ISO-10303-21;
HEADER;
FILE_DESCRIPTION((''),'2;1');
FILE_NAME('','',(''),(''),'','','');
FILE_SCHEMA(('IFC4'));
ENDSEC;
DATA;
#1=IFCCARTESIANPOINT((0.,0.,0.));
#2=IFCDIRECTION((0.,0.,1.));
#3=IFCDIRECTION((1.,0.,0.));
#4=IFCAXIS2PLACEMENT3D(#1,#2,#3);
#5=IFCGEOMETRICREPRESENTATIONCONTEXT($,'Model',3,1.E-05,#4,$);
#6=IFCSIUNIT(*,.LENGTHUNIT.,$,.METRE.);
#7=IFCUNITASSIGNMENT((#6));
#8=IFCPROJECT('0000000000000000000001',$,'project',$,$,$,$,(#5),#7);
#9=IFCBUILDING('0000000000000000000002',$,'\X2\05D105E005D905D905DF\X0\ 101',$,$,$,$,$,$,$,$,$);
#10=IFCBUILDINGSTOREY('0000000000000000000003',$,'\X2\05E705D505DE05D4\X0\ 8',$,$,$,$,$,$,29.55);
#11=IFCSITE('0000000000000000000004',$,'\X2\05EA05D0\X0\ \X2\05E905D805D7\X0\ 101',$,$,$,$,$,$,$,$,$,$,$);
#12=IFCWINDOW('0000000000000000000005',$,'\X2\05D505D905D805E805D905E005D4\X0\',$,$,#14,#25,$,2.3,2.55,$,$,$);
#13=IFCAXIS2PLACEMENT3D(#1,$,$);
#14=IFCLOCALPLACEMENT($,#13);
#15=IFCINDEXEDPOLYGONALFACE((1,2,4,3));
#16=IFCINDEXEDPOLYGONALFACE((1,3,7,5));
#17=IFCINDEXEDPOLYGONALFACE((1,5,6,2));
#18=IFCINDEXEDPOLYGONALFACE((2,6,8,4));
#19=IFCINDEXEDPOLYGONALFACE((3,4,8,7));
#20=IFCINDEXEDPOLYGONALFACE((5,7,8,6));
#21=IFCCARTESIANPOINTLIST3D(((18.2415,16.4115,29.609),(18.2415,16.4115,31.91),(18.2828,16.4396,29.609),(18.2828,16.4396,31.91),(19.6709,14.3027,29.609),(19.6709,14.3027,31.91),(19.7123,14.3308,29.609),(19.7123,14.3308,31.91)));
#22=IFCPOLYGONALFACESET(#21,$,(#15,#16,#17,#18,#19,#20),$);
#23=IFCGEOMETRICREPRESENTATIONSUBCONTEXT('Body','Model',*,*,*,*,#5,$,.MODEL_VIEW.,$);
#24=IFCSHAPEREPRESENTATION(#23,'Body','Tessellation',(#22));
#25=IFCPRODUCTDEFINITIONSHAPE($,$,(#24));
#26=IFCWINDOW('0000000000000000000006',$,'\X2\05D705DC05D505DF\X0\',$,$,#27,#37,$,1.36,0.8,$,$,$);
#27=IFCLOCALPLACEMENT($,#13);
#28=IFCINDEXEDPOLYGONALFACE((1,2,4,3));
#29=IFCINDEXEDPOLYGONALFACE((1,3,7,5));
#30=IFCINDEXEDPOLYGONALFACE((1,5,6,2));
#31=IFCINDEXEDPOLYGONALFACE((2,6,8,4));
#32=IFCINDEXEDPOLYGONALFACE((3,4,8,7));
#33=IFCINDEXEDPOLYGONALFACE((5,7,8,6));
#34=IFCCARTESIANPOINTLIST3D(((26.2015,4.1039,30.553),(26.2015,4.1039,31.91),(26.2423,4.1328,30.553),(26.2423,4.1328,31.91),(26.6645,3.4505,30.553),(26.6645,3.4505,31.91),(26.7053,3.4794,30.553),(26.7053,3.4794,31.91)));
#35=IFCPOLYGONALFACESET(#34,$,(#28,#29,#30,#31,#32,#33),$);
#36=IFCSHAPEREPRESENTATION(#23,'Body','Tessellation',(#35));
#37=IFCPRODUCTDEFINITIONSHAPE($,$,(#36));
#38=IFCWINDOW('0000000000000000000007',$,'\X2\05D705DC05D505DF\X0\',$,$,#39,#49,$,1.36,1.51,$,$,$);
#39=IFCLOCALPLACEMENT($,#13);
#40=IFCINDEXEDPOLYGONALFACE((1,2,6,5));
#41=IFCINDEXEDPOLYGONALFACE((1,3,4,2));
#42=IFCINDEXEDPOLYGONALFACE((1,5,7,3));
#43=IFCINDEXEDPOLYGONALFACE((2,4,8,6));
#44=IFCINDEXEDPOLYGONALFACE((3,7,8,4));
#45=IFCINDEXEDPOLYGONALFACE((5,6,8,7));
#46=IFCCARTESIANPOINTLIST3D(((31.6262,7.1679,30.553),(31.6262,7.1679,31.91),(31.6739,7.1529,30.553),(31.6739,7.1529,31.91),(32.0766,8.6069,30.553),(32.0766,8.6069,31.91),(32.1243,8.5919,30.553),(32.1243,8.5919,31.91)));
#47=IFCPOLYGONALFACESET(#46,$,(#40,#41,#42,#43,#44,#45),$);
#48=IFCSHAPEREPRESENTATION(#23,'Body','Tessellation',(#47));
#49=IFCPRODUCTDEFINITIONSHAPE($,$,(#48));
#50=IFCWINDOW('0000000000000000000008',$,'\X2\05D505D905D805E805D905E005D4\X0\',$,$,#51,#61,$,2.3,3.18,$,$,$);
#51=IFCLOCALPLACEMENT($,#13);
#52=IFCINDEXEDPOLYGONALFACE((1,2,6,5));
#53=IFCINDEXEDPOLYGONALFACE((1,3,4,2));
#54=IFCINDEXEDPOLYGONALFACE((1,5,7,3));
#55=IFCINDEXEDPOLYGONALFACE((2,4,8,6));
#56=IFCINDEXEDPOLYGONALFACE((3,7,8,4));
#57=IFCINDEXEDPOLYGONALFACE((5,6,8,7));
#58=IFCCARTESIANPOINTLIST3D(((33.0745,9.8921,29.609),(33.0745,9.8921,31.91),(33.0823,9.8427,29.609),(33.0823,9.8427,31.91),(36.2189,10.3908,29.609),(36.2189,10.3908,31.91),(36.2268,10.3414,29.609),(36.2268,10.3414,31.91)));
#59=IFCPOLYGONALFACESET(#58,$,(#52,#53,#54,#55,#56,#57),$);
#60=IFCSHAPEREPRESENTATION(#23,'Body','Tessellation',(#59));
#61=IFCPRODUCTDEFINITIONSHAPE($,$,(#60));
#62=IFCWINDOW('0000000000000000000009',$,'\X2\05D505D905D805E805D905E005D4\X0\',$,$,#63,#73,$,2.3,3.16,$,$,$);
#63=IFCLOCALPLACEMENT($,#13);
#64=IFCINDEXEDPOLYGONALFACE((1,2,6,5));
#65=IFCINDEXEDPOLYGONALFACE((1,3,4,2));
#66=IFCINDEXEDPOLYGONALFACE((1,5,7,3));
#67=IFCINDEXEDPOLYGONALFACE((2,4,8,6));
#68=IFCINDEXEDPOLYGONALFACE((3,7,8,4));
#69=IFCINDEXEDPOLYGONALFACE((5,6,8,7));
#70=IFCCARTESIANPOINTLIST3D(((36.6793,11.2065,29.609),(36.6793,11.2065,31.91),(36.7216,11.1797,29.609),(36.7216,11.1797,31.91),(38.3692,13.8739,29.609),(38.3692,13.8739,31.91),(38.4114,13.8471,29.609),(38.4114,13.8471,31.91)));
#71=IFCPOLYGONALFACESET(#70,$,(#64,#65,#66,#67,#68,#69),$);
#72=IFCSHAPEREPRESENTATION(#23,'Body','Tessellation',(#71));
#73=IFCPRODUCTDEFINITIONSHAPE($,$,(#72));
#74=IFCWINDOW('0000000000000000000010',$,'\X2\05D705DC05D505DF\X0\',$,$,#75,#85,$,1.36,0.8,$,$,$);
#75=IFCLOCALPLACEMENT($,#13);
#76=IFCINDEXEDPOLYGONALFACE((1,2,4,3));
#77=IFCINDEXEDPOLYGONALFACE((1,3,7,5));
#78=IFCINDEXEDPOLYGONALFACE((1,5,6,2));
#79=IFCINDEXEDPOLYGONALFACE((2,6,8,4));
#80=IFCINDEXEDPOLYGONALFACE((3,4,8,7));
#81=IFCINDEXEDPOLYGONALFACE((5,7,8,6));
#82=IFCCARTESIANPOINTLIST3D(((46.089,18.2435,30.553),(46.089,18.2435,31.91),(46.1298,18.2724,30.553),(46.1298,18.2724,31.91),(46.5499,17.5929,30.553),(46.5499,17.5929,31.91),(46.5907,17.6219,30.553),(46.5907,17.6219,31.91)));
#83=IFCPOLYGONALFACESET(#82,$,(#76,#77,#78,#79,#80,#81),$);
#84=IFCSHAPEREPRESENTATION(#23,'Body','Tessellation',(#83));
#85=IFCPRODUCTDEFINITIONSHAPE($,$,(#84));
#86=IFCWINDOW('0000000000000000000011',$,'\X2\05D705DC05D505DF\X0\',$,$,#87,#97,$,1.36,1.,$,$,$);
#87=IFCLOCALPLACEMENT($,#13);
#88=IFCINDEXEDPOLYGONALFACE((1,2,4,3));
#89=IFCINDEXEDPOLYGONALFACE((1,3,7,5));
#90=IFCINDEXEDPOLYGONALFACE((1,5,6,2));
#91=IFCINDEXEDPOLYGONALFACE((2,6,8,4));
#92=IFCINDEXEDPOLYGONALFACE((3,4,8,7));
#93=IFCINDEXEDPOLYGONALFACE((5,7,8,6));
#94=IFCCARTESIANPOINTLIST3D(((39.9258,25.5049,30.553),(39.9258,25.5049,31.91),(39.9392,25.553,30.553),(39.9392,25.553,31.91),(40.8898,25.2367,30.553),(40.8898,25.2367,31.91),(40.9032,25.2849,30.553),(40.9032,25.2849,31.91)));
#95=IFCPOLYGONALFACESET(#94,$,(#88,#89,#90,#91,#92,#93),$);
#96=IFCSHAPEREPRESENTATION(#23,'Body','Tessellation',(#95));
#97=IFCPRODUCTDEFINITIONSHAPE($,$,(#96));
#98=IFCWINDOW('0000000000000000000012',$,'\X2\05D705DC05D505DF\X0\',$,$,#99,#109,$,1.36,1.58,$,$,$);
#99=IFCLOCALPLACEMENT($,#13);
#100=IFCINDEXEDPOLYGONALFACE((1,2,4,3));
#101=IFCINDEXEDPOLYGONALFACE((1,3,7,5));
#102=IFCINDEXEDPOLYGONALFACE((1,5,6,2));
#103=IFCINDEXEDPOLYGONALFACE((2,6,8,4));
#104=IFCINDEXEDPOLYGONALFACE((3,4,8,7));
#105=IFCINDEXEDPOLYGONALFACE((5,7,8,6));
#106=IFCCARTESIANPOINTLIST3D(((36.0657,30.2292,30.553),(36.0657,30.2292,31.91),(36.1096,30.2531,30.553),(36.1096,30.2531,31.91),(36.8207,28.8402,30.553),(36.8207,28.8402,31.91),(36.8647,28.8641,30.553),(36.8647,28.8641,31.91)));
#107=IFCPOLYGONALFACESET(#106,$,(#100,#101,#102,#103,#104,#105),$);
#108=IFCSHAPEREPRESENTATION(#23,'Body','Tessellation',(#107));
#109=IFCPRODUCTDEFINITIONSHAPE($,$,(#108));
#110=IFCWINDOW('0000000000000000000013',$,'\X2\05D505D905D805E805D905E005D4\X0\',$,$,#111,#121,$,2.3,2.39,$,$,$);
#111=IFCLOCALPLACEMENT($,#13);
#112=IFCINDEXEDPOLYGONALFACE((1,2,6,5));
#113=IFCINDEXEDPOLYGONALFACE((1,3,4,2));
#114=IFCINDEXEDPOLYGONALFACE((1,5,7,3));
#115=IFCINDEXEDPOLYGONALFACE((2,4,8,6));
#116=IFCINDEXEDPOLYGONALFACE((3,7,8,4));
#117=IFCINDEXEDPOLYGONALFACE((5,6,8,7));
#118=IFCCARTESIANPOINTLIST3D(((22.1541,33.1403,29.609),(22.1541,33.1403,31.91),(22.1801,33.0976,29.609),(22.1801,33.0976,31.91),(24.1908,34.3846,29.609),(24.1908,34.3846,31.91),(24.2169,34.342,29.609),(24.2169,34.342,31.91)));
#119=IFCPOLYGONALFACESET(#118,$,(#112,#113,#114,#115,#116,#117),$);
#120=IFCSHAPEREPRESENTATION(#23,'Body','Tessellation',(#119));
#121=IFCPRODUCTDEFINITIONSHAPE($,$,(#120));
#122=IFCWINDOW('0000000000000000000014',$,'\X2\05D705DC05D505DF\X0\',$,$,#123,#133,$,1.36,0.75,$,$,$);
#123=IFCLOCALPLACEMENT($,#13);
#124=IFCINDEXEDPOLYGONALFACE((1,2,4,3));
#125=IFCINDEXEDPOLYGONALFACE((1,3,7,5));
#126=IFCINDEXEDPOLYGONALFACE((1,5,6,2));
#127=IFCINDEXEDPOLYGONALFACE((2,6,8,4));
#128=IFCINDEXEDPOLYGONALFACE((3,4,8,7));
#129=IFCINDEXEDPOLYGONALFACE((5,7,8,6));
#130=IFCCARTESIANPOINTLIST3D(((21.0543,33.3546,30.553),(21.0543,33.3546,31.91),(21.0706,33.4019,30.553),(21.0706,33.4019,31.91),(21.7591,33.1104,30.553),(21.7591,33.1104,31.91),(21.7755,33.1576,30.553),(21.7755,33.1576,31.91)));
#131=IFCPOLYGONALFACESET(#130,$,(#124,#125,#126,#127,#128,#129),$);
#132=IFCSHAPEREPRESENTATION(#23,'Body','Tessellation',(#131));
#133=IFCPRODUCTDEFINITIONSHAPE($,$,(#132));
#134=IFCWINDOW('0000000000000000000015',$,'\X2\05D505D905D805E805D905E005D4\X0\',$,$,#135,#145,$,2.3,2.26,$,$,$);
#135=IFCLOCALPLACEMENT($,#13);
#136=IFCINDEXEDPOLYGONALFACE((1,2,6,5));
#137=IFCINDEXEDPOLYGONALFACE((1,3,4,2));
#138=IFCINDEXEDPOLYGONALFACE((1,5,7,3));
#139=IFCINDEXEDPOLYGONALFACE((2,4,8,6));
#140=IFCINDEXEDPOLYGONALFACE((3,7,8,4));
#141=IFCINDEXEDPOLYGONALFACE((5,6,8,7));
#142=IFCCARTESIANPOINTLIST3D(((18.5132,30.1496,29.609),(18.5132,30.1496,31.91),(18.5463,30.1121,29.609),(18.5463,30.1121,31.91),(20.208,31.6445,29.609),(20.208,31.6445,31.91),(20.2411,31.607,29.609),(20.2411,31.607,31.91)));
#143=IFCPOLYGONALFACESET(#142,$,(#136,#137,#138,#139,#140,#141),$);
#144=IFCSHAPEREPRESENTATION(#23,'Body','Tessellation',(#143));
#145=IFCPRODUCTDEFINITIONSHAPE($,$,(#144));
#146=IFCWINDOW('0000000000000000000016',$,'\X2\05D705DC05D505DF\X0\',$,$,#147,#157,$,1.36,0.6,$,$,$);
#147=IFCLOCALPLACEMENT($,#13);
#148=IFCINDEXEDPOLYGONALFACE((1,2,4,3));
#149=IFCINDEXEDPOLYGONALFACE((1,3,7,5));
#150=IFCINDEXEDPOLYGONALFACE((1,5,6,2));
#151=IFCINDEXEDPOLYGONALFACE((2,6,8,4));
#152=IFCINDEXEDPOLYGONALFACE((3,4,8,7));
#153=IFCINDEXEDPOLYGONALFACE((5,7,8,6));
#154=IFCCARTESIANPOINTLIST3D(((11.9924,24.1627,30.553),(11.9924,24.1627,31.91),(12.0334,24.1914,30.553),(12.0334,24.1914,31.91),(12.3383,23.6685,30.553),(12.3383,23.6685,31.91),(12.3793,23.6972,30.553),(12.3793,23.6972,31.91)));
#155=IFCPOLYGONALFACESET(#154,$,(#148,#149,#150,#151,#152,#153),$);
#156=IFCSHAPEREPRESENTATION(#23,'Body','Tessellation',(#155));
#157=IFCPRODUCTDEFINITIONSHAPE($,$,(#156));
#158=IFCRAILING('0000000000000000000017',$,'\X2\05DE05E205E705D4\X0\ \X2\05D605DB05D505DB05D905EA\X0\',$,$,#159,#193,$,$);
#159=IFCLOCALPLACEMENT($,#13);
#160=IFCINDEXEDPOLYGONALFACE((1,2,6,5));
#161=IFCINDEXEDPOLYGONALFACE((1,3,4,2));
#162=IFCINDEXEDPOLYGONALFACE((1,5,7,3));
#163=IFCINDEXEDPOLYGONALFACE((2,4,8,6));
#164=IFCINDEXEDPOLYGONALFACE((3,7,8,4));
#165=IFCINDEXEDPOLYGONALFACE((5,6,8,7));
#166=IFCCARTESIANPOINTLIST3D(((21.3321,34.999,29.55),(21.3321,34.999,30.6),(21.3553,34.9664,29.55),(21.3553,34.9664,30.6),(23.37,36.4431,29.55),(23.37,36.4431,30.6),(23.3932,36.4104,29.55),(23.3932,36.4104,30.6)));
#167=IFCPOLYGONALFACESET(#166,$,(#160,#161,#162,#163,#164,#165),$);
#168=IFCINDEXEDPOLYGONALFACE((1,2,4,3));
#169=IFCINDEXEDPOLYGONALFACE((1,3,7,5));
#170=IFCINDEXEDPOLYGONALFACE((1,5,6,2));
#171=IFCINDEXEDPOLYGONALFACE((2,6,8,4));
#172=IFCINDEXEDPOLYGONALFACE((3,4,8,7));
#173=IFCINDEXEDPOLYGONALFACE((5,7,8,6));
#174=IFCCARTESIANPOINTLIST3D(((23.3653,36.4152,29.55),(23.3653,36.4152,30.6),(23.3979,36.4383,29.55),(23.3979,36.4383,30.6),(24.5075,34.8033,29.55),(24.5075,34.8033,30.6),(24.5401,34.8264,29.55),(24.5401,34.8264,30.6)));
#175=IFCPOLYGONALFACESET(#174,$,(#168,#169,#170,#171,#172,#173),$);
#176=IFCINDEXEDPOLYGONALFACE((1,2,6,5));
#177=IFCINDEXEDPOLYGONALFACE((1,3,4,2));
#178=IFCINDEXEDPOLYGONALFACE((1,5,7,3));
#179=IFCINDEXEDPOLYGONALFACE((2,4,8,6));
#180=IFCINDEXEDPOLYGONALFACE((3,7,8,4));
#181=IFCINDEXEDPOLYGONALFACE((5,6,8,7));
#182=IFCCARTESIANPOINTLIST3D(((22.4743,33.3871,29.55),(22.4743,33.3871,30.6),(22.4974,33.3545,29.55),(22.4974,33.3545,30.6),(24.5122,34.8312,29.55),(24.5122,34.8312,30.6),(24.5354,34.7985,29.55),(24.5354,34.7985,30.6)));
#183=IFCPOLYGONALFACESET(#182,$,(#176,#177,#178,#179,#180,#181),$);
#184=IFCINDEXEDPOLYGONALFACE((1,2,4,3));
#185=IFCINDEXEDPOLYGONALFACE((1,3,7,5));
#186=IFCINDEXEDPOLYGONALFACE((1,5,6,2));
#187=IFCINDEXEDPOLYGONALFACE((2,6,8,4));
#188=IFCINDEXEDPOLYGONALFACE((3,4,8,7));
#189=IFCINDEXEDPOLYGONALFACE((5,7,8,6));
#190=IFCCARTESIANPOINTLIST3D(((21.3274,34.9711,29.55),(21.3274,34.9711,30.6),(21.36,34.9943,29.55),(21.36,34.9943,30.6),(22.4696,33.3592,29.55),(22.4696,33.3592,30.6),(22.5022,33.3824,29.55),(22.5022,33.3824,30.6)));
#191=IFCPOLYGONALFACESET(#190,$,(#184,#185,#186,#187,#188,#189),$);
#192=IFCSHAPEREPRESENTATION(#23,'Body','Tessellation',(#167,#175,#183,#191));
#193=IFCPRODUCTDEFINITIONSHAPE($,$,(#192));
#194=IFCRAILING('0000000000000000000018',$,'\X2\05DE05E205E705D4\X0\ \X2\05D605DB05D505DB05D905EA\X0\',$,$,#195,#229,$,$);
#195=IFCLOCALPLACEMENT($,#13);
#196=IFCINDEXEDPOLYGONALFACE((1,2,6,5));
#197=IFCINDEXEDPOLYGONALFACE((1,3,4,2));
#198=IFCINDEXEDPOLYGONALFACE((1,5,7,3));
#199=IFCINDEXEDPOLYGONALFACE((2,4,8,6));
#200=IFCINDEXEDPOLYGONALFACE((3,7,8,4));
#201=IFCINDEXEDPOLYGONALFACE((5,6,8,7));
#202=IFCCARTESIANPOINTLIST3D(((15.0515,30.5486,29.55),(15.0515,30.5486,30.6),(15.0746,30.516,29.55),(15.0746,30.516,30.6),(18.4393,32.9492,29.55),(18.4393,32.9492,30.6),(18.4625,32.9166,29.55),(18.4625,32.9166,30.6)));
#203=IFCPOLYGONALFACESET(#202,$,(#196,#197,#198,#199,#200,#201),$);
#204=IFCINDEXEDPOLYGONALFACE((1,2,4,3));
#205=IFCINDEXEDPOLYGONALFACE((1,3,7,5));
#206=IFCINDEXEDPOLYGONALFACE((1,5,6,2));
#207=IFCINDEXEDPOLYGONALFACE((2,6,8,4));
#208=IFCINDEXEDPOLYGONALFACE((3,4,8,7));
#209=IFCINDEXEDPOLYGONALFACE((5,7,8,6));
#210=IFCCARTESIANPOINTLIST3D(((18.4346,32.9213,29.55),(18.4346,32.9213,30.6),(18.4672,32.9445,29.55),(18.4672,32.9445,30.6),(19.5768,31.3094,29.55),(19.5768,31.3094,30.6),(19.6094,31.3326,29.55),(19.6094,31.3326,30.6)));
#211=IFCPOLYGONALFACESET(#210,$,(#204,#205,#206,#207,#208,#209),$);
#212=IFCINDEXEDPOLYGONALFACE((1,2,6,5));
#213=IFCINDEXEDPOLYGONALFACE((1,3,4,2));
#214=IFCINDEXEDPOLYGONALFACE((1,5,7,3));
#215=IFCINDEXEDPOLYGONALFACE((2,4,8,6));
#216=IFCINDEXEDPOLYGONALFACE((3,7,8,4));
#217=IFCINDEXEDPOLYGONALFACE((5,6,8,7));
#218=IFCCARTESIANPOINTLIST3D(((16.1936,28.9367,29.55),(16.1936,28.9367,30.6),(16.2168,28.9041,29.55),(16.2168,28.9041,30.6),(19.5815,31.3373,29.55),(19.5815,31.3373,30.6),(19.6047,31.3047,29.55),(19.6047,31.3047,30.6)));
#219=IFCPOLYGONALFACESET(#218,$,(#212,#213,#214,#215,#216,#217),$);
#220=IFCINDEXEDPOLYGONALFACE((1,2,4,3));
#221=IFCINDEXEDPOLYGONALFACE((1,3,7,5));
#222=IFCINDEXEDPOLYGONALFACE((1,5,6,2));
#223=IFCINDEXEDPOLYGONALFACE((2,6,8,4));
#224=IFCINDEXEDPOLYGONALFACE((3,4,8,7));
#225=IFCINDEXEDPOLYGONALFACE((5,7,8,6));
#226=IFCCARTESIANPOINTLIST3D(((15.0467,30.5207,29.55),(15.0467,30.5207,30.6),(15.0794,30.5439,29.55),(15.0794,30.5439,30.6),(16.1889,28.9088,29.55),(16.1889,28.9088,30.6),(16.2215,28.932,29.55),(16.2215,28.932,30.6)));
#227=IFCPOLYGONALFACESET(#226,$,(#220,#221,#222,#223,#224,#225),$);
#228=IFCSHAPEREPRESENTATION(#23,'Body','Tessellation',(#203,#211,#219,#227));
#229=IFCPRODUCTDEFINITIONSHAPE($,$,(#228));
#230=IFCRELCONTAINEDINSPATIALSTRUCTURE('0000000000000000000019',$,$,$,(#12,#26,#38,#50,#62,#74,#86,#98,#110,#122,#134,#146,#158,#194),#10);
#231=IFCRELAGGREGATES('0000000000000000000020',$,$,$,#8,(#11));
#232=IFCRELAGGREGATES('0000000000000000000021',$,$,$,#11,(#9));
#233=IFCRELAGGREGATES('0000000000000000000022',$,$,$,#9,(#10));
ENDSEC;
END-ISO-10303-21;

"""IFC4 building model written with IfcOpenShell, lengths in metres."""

from ifc_helpers import new_model, si_unit, frame, origin_with_axes, context, subcontext, project, spatial, polyline, outline, extrude, element, save


model = new_model("IFC4")

# Units and contexts
model_context = context("Model", 3, precision=1e-05, world=origin_with_axes())
body_context = subcontext(model_context, "Body", "Model", "MODEL_VIEW")
ifc_project = project(units=[si_unit("LENGTHUNIT", "METRE")], contexts=[model_context])

# Site, building, storey
site = spatial("IfcSite", under=ifc_project, Name="תא שטח 101")
building = spatial("IfcBuilding", under=site, Name="בניין 101")
storey = spatial("IfcBuildingStorey", under=building, Name="קומה 8", Elevation=29.55)

# Windows
element("IfcWindow", 1, inside=storey, Name="ויטרינה", OverallHeight=2.3, OverallWidth=2.55, context=body_context, shape_type="SweptSolid", body=[
    extrude(outline(polyline([(18.2415, 16.4115), (19.6709, 14.3027), (19.7123, 14.3308), (18.2828, 16.4396), (18.2415, 16.4115)])), frame((0.0, 0.0, 29.609)), (0.0, 0.0, 1.0), 2.301),
])
element("IfcWindow", 2, inside=storey, Name="חלון", OverallHeight=1.36, OverallWidth=0.8, context=body_context, shape_type="SweptSolid", body=[
    extrude(outline(polyline([(26.2015, 4.1039), (26.6645, 3.4505), (26.7053, 3.4794), (26.2423, 4.1328), (26.2015, 4.1039)])), frame((0.0, 0.0, 30.553)), (0.0, 0.0, 1.0), 1.357),
])
element("IfcWindow", 3, inside=storey, Name="חלון", OverallHeight=1.36, OverallWidth=1.51, context=body_context, shape_type="SweptSolid", body=[
    extrude(outline(polyline([(31.6739, 7.1529), (32.1243, 8.5919), (32.0766, 8.6069), (31.6262, 7.1679), (31.6739, 7.1529)])), frame((0.0, 0.0, 30.553)), (0.0, 0.0, 1.0), 1.357),
])
element("IfcWindow", 4, inside=storey, Name="ויטרינה", OverallHeight=2.3, OverallWidth=3.18, context=body_context, shape_type="SweptSolid", body=[
    extrude(outline(polyline([(33.0823, 9.8427), (36.2268, 10.3414), (36.2189, 10.3908), (33.0745, 9.8921), (33.0823, 9.8427)])), frame((0.0, 0.0, 29.609)), (0.0, 0.0, 1.0), 2.301),
])
element("IfcWindow", 5, inside=storey, Name="ויטרינה", OverallHeight=2.3, OverallWidth=3.16, context=body_context, shape_type="SweptSolid", body=[
    extrude(outline(polyline([(36.7216, 11.1797), (38.4114, 13.8471), (38.3692, 13.8739), (36.6793, 11.2065), (36.7216, 11.1797)])), frame((0.0, 0.0, 29.609)), (0.0, 0.0, 1.0), 2.301),
])
element("IfcWindow", 6, inside=storey, Name="חלון", OverallHeight=1.36, OverallWidth=0.8, context=body_context, shape_type="SweptSolid", body=[
    extrude(outline(polyline([(46.5907, 17.6219), (46.1298, 18.2724), (46.089, 18.2435), (46.5499, 17.5929), (46.5907, 17.6219)])), frame((0.0, 0.0, 30.553)), (0.0, 0.0, 1.0), 1.357),
])
element("IfcWindow", 7, inside=storey, Name="חלון", OverallHeight=1.36, OverallWidth=1.0, context=body_context, shape_type="SweptSolid", body=[
    extrude(outline(polyline([(40.9032, 25.2849), (39.9392, 25.553), (39.9258, 25.5049), (40.8898, 25.2367), (40.9032, 25.2849)])), frame((0.0, 0.0, 30.553)), (0.0, 0.0, 1.0), 1.357),
])
element("IfcWindow", 8, inside=storey, Name="חלון", OverallHeight=1.36, OverallWidth=1.58, context=body_context, shape_type="SweptSolid", body=[
    extrude(outline(polyline([(36.8647, 28.8641), (36.1096, 30.2531), (36.0657, 30.2292), (36.8207, 28.8402), (36.8647, 28.8641)])), frame((0.0, 0.0, 30.553)), (0.0, 0.0, 1.0), 1.357),
])
element("IfcWindow", 9, inside=storey, Name="ויטרינה", OverallHeight=2.3, OverallWidth=2.39, context=body_context, shape_type="SweptSolid", body=[
    extrude(outline(polyline([(24.1908, 34.3846), (22.1541, 33.1403), (22.1801, 33.0976), (24.2169, 34.342), (24.1908, 34.3846)])), frame((0.0, 0.0, 29.609)), (0.0, 0.0, 1.0), 2.301),
])
element("IfcWindow", 10, inside=storey, Name="חלון", OverallHeight=1.36, OverallWidth=0.75, context=body_context, shape_type="SweptSolid", body=[
    extrude(outline(polyline([(21.7755, 33.1576), (21.0706, 33.4019), (21.0543, 33.3546), (21.7591, 33.1104), (21.7755, 33.1576)])), frame((0.0, 0.0, 30.553)), (0.0, 0.0, 1.0), 1.357),
])
element("IfcWindow", 11, inside=storey, Name="ויטרינה", OverallHeight=2.3, OverallWidth=2.26, context=body_context, shape_type="SweptSolid", body=[
    extrude(outline(polyline([(20.208, 31.6445), (18.5132, 30.1496), (18.5463, 30.1121), (20.2411, 31.607), (20.208, 31.6445)])), frame((0.0, 0.0, 29.609)), (0.0, 0.0, 1.0), 2.301),
])
element("IfcWindow", 12, inside=storey, Name="חלון", OverallHeight=1.36, OverallWidth=0.6, context=body_context, shape_type="SweptSolid", body=[
    extrude(outline(polyline([(11.9924, 24.1627), (12.3383, 23.6685), (12.3793, 23.6972), (12.0334, 24.1914), (11.9924, 24.1627)])), frame((0.0, 0.0, 30.553)), (0.0, 0.0, 1.0), 1.357),
])

# Railings
element("IfcRailing", 13, inside=storey, Name="מעקה זכוכית", context=body_context, shape_type="SweptSolid", body=[
    extrude(outline(polyline([(21.3553, 34.9664), (23.3932, 36.4104), (23.37, 36.4431), (21.3321, 34.999), (21.3553, 34.9664)])), frame((0.0, 0.0, 29.55)), (0.0, 0.0, 1.0), 1.05),
    extrude(outline(polyline([(23.3653, 36.4152), (24.5075, 34.8033), (24.5401, 34.8264), (23.3979, 36.4383), (23.3653, 36.4152)])), frame((0.0, 0.0, 29.55)), (0.0, 0.0, 1.0), 1.05),
    extrude(outline(polyline([(24.5122, 34.8312), (22.4743, 33.3871), (22.4974, 33.3545), (24.5354, 34.7985), (24.5122, 34.8312)])), frame((0.0, 0.0, 29.55)), (0.0, 0.0, 1.0), 1.05),
    extrude(outline(polyline([(22.5022, 33.3824), (21.36, 34.9943), (21.3274, 34.9711), (22.4696, 33.3592), (22.5022, 33.3824)])), frame((0.0, 0.0, 29.55)), (0.0, 0.0, 1.0), 1.05),
])
element("IfcRailing", 14, inside=storey, Name="מעקה זכוכית", context=body_context, shape_type="SweptSolid", body=[
    extrude(outline(polyline([(15.0746, 30.516), (18.4625, 32.9166), (18.4393, 32.9492), (15.0515, 30.5486), (15.0746, 30.516)])), frame((0.0, 0.0, 29.55)), (0.0, 0.0, 1.0), 1.05),
    extrude(outline(polyline([(18.4346, 32.9213), (19.5768, 31.3094), (19.6094, 31.3326), (18.4672, 32.9445), (18.4346, 32.9213)])), frame((0.0, 0.0, 29.55)), (0.0, 0.0, 1.0), 1.05),
    extrude(outline(polyline([(19.5815, 31.3373), (16.1936, 28.9367), (16.2168, 28.9041), (19.6047, 31.3047), (19.5815, 31.3373)])), frame((0.0, 0.0, 29.55)), (0.0, 0.0, 1.0), 1.05),
    extrude(outline(polyline([(16.2215, 28.932), (15.0794, 30.5439), (15.0467, 30.5207), (16.1889, 28.9088), (16.2215, 28.932)])), frame((0.0, 0.0, 29.55)), (0.0, 0.0, 1.0), 1.05),
])

save(model, "model.ifc")
